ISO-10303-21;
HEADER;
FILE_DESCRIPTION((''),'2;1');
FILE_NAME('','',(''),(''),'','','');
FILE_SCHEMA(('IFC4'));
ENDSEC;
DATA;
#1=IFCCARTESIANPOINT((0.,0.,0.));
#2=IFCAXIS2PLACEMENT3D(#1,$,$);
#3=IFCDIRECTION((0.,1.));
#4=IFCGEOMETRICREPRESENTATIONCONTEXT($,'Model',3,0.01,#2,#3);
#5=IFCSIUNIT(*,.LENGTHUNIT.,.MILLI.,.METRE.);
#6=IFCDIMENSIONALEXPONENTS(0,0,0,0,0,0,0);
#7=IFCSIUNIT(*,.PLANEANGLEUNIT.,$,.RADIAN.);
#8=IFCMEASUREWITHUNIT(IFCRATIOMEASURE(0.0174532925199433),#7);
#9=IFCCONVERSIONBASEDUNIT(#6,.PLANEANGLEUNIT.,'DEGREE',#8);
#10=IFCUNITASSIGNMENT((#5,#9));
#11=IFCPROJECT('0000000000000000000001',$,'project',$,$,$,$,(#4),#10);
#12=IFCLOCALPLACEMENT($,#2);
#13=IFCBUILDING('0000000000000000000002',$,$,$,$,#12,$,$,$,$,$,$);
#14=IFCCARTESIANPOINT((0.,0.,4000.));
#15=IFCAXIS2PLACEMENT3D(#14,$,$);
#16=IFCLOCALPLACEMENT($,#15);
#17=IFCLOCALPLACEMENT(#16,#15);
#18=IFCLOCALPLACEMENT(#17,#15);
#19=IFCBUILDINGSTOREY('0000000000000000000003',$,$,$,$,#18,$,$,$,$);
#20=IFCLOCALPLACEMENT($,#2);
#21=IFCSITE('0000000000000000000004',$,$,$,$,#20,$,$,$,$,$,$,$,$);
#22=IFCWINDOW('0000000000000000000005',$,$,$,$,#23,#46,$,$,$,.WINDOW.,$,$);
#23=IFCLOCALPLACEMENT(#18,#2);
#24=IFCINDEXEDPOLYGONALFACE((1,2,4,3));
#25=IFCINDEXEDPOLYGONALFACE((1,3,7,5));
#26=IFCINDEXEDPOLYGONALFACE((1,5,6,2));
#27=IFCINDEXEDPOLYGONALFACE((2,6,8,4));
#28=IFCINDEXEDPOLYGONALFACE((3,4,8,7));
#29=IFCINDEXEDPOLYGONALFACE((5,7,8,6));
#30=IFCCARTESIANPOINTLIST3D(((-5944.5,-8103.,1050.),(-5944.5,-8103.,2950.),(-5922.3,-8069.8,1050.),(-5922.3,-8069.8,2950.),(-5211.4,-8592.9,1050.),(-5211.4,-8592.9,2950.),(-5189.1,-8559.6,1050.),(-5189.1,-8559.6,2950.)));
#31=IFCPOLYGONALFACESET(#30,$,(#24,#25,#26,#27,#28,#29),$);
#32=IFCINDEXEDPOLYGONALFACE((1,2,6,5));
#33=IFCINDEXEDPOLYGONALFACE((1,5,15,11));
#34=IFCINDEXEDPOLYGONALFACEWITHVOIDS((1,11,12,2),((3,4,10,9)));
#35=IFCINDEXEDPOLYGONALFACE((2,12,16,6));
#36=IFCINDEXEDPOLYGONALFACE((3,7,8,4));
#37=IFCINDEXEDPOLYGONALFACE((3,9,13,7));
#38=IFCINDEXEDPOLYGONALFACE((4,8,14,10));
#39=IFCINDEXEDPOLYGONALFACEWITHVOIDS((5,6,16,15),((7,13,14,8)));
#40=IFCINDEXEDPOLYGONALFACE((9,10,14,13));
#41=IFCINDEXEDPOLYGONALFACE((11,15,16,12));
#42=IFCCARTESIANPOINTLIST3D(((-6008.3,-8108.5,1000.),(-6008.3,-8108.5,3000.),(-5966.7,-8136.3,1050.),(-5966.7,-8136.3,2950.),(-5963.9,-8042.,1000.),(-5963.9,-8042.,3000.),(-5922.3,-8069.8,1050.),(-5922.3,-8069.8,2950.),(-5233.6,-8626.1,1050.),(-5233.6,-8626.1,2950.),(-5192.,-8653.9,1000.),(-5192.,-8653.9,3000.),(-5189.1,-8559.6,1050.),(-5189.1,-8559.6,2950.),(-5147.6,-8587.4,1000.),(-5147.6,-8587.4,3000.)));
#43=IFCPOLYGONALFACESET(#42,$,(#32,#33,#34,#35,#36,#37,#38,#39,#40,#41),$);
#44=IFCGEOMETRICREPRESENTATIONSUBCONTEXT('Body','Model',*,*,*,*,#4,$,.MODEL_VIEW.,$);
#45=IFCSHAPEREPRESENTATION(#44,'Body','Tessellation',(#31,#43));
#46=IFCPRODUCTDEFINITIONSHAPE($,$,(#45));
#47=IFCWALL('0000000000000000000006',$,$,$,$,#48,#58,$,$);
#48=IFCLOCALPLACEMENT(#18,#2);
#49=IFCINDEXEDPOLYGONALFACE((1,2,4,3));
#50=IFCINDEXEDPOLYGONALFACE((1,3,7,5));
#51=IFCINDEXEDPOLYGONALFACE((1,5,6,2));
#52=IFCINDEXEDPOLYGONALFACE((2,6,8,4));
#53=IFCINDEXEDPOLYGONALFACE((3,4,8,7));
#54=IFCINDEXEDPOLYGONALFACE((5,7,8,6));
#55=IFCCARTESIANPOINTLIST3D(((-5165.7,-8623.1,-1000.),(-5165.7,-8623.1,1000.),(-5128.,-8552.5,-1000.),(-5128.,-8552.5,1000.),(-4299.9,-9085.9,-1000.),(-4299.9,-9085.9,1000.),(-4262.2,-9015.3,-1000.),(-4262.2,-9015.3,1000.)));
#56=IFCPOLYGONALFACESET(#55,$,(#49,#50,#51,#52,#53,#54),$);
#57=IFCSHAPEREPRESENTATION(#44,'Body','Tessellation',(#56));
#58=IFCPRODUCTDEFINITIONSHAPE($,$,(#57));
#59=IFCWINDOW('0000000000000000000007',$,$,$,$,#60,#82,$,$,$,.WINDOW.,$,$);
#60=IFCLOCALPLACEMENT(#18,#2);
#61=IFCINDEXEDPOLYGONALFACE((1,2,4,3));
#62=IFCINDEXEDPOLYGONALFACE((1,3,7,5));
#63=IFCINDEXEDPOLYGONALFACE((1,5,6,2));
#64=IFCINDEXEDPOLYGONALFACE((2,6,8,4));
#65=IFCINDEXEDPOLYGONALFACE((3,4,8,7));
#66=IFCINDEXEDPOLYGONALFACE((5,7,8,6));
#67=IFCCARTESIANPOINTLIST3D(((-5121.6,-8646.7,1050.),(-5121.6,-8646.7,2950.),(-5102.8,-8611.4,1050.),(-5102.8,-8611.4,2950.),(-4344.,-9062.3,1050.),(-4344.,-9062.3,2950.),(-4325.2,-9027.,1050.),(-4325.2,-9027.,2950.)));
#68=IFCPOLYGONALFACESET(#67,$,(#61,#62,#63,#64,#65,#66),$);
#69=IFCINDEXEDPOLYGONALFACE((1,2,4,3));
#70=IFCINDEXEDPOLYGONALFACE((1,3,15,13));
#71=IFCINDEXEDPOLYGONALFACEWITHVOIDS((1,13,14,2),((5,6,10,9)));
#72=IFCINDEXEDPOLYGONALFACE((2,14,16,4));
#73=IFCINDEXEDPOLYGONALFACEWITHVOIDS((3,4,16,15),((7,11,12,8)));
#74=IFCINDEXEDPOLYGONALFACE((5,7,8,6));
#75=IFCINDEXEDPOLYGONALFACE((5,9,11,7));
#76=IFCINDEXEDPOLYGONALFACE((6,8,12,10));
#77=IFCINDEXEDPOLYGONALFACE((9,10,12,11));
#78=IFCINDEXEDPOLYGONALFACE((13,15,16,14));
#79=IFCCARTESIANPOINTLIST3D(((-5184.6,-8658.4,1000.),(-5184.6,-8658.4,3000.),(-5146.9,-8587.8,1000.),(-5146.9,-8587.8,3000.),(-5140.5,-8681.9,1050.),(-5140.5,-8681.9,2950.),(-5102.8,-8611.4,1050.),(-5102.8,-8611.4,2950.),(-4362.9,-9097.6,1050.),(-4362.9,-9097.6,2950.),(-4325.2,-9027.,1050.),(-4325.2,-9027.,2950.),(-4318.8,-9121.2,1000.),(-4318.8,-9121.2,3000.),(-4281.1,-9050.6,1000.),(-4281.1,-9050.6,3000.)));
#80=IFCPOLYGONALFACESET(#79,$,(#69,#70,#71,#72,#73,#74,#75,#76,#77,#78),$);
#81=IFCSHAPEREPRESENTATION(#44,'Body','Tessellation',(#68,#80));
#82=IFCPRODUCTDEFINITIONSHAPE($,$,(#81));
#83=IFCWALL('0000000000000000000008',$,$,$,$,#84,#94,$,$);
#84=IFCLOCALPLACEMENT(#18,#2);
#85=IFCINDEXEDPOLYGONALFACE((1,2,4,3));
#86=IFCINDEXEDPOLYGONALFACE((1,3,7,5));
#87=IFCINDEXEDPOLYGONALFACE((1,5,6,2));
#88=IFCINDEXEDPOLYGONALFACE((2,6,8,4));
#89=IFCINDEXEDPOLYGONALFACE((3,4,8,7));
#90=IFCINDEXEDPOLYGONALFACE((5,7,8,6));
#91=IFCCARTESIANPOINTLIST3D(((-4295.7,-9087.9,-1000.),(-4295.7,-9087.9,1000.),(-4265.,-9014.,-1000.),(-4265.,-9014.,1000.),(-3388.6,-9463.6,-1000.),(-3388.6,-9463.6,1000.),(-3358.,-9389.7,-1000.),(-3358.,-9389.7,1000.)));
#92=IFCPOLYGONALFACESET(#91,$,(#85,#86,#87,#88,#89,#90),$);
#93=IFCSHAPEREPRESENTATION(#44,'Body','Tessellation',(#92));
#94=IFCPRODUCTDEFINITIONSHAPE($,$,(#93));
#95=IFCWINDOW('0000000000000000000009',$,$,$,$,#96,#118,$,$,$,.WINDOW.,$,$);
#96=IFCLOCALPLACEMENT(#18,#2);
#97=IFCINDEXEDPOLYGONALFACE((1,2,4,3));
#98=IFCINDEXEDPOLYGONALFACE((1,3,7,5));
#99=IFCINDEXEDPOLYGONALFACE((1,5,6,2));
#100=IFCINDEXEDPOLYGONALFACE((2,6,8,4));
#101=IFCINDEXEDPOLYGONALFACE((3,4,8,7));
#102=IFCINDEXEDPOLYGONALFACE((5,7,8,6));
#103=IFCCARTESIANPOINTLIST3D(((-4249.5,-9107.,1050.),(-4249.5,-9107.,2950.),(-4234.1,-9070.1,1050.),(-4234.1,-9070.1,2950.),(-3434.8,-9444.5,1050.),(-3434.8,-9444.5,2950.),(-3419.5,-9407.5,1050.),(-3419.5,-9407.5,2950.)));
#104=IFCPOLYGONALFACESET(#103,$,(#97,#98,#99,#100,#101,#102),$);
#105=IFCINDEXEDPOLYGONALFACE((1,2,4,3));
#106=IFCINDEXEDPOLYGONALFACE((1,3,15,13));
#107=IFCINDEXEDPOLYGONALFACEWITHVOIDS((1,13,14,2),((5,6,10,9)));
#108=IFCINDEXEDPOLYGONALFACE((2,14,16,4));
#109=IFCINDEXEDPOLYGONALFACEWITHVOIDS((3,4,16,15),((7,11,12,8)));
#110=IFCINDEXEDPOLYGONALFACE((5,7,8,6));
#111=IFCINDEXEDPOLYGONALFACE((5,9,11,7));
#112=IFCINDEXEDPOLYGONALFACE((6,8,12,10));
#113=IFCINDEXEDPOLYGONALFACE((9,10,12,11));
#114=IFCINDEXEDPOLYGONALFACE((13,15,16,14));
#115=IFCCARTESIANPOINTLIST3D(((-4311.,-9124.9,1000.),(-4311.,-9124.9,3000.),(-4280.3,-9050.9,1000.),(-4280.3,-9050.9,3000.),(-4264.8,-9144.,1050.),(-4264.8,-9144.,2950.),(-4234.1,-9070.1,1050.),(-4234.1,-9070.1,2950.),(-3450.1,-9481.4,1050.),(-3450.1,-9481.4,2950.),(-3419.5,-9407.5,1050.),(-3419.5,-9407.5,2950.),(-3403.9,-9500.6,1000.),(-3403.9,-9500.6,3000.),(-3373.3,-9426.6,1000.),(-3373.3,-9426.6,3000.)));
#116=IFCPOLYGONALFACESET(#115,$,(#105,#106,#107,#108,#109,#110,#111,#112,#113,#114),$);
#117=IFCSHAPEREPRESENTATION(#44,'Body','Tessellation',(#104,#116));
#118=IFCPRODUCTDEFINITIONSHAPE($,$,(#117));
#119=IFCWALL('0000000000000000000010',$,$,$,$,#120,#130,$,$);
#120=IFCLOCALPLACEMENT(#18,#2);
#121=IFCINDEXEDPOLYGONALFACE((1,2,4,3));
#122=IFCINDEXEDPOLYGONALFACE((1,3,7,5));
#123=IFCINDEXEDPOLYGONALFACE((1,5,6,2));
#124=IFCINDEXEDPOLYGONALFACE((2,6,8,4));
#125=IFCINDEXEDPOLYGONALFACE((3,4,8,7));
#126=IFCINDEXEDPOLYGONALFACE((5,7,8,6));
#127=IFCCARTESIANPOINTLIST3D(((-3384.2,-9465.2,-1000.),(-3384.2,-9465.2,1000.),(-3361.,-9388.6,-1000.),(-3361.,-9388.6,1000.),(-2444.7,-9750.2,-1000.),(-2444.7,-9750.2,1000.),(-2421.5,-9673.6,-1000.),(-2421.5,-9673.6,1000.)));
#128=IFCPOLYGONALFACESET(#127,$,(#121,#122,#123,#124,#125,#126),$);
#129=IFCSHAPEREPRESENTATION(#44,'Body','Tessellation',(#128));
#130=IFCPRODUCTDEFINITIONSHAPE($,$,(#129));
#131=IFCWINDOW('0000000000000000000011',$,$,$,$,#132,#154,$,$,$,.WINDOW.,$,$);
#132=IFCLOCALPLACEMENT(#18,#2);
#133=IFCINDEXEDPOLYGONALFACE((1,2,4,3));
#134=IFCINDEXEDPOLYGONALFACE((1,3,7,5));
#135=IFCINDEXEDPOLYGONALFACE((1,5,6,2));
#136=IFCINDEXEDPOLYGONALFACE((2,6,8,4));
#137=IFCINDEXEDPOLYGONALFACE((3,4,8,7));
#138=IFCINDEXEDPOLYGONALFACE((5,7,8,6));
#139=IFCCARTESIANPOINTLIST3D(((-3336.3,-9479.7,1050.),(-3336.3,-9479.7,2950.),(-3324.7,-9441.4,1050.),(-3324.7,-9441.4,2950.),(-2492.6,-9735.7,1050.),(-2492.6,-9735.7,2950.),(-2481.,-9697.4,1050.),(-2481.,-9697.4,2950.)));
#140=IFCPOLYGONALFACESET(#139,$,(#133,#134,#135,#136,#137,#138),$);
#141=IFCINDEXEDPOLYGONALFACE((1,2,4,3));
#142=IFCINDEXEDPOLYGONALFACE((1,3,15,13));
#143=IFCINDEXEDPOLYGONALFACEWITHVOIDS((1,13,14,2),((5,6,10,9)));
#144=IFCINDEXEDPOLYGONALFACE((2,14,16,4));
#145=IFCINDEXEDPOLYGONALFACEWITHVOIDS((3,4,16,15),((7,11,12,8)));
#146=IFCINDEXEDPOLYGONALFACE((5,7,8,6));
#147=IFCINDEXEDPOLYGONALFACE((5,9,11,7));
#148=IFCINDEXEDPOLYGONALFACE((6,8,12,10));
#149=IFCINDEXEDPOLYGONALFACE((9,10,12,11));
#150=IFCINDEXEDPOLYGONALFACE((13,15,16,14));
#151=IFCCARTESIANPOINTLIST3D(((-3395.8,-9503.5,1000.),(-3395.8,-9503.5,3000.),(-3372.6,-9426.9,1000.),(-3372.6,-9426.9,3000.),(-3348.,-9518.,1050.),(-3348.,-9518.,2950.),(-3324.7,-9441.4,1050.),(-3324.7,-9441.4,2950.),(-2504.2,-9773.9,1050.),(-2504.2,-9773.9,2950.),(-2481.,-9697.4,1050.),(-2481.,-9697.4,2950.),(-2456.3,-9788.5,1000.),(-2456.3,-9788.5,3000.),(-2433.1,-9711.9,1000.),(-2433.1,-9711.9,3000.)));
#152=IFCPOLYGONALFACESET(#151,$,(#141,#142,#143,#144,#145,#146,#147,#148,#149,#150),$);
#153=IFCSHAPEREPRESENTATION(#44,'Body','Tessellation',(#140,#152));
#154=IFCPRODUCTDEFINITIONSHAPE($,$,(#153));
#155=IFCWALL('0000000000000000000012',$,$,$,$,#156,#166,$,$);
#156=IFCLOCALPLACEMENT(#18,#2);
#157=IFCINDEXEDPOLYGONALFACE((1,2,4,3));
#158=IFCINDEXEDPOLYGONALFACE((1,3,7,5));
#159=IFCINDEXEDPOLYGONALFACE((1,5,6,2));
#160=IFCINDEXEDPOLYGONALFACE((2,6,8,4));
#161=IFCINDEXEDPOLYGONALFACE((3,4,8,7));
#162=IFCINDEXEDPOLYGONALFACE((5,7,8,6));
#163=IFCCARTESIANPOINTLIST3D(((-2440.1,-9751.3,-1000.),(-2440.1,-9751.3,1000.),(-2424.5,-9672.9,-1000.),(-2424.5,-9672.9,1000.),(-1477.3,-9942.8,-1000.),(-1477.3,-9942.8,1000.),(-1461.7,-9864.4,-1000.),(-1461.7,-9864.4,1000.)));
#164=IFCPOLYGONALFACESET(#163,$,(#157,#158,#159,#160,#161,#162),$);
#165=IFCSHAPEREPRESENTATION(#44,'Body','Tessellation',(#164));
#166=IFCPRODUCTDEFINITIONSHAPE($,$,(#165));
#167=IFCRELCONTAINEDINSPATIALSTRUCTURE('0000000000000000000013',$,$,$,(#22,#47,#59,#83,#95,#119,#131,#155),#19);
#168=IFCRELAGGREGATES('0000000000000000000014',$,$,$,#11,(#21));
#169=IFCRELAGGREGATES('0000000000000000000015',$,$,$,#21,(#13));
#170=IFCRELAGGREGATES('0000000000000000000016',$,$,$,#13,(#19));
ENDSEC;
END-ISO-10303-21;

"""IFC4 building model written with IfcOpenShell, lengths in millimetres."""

from ifc_helpers import new_model, entity, si_unit, converted_unit, direction, frame, origin, origin_2d, place, context, subcontext, project, spatial, rectangle, extrude, element, save


model = new_model("IFC4")

# Units and contexts
model_context = context("Model", 3, precision=0.01, world=origin(), true_north=direction((0.0, 1.0)))
body_context = subcontext(model_context, "Body", "Model", "MODEL_VIEW")
ifc_project = project(units=[si_unit("LENGTHUNIT", "METRE", prefix="MILLI"), converted_unit("PLANEANGLEUNIT", "DEGREE", entity("IfcRatioMeasure", 0.0174532925199433), si_unit("PLANEANGLEUNIT", "RADIAN"), dimensions=[0, 0, 0, 0, 0, 0, 0])], contexts=[model_context])

# Site, building, storey
site_placement = place(None, origin())
site = spatial("IfcSite", under=ifc_project, at=site_placement)
building_placement = place(None, origin())
building = spatial("IfcBuilding", under=site, at=building_placement)
placement_1 = place(None, frame((0.0, 0.0, 4000.0)))
placement_2 = place(placement_1, frame((0.0, 0.0, 4000.0)))
storey_placement = place(placement_2, frame((0.0, 0.0, 4000.0)))
storey = spatial("IfcBuildingStorey", under=building, at=storey_placement)

# Shared definitions
cartesian_point_1 = entity("IfcCartesianPoint", [-440.9, -950.0])
shared_polyline = entity("IfcPolyline", [cartesian_point_1, entity("IfcCartesianPoint", [-440.9, 950.0]), entity("IfcCartesianPoint", [-440.9, 950.0]), entity("IfcCartesianPoint", [440.9, 950.0]), entity("IfcCartesianPoint", [440.9, 950.0]), entity("IfcCartesianPoint", [440.9, -950.0]), entity("IfcCartesianPoint", [440.9, -950.0]), entity("IfcCartesianPoint", [-440.9, -950.0]), cartesian_point_1])

# Window
window_1_placement = place(storey_placement, frame((-5555.7, -8314.7, 2000.0), z_axis=(0.0, 0.0, 1.0), x_axis=(8314.694856, -5555.704226, 0.0)))
cartesian_point_2 = entity("IfcCartesianPoint", [-490.9, -1000.0])
element("IfcWindow", 1, at=window_1_placement, inside=storey, PredefinedType="WINDOW", context=body_context, shape_type="SweptSolid", body=[
    entity("IfcExtrudedAreaSolid", entity("IfcArbitraryClosedProfileDef", "AREA", None, shared_polyline), entity("IfcAxis2Placement3D", entity("IfcCartesianPoint", [0.0, 0.0, 0.0]), entity("IfcDirection", [0.0, -1.0, 0.0]), entity("IfcDirection", [1.0, 0.0, 0.0])), entity("IfcDirection", [0.0, 0.0, 1.0]), 40.0),
    entity("IfcExtrudedAreaSolid", entity("IfcArbitraryProfileDefWithVoids", "AREA", None, entity("IfcPolyline", [cartesian_point_2, entity("IfcCartesianPoint", [-490.9, 1000.0]), entity("IfcCartesianPoint", [-490.9, 1000.0]), entity("IfcCartesianPoint", [490.9, 1000.0]), entity("IfcCartesianPoint", [490.9, 1000.0]), entity("IfcCartesianPoint", [490.9, -1000.0]), entity("IfcCartesianPoint", [490.9, -1000.0]), entity("IfcCartesianPoint", [-490.9, -1000.0]), cartesian_point_2]), [shared_polyline]), entity("IfcAxis2Placement3D", entity("IfcCartesianPoint", [0.0, 0.0, 0.0]), entity("IfcDirection", [0.0, -1.0, 0.0]), entity("IfcDirection", [1.0, 0.0, 0.0])), entity("IfcDirection", [0.0, 0.0, 1.0]), 80.0),
])

# Wall
wall_1_placement = place(storey_placement, frame((-4714.0, -8819.2, -1000.0), z_axis=(0.0, 0.0, 1.0), x_axis=(8819.212881, -4713.966924, 0.0)))
element("IfcWall", 2, at=wall_1_placement, inside=storey, context=body_context, shape_type="SweptSolid", body=[
    extrude(rectangle(XDim=981.7, YDim=80.0, at=origin_2d()), origin(), (0.0, 0.0, 1.0), 2000.0),
])

# Window
window_2_placement = place(storey_placement, frame((-4714.0, -8819.2, 2000.0), z_axis=(0.0, 0.0, 1.0), x_axis=(8819.212881, -4713.966924, 0.0)))
cartesian_point_3 = entity("IfcCartesianPoint", [-490.9, -1000.0])
element("IfcWindow", 3, at=window_2_placement, inside=storey, PredefinedType="WINDOW", context=body_context, shape_type="SweptSolid", body=[
    entity("IfcExtrudedAreaSolid", entity("IfcArbitraryClosedProfileDef", "AREA", None, shared_polyline), entity("IfcAxis2Placement3D", entity("IfcCartesianPoint", [0.0, 0.0, 0.0]), entity("IfcDirection", [0.0, -1.0, 0.0]), entity("IfcDirection", [1.0, 0.0, 0.0])), entity("IfcDirection", [0.0, 0.0, 1.0]), 40.0),
    entity("IfcExtrudedAreaSolid", entity("IfcArbitraryProfileDefWithVoids", "AREA", None, entity("IfcPolyline", [cartesian_point_3, entity("IfcCartesianPoint", [-490.9, 1000.0]), entity("IfcCartesianPoint", [-490.9, 1000.0]), entity("IfcCartesianPoint", [490.9, 1000.0]), entity("IfcCartesianPoint", [490.9, 1000.0]), entity("IfcCartesianPoint", [490.9, -1000.0]), entity("IfcCartesianPoint", [490.9, -1000.0]), entity("IfcCartesianPoint", [-490.9, -1000.0]), cartesian_point_3]), [shared_polyline]), entity("IfcAxis2Placement3D", entity("IfcCartesianPoint", [0.0, 0.0, 0.0]), entity("IfcDirection", [0.0, -1.0, 0.0]), entity("IfcDirection", [1.0, 0.0, 0.0])), entity("IfcDirection", [0.0, 0.0, 1.0]), 80.0),
])

# Wall
wall_2_placement = place(storey_placement, frame((-3826.8, -9238.8, -1000.0), z_axis=(0.0, 0.0, 1.0), x_axis=(9238.794759, -3826.835691, 0.0)))
element("IfcWall", 4, at=wall_2_placement, inside=storey, context=body_context, shape_type="SweptSolid", body=[
    extrude(rectangle(XDim=981.7, YDim=80.0, at=origin_2d()), origin(), (0.0, 0.0, 1.0), 2000.0),
])

# Window
window_3_placement = place(storey_placement, frame((-3826.8, -9238.8, 2000.0), z_axis=(0.0, 0.0, 1.0), x_axis=(9238.794759, -3826.835691, 0.0)))
cartesian_point_4 = entity("IfcCartesianPoint", [-490.9, -1000.0])
element("IfcWindow", 5, at=window_3_placement, inside=storey, PredefinedType="WINDOW", context=body_context, shape_type="SweptSolid", body=[
    entity("IfcExtrudedAreaSolid", entity("IfcArbitraryClosedProfileDef", "AREA", None, shared_polyline), entity("IfcAxis2Placement3D", entity("IfcCartesianPoint", [0.0, 0.0, 0.0]), entity("IfcDirection", [0.0, -1.0, 0.0]), entity("IfcDirection", [1.0, 0.0, 0.0])), entity("IfcDirection", [0.0, 0.0, 1.0]), 40.0),
    entity("IfcExtrudedAreaSolid", entity("IfcArbitraryProfileDefWithVoids", "AREA", None, entity("IfcPolyline", [cartesian_point_4, entity("IfcCartesianPoint", [-490.9, 1000.0]), entity("IfcCartesianPoint", [-490.9, 1000.0]), entity("IfcCartesianPoint", [490.9, 1000.0]), entity("IfcCartesianPoint", [490.9, 1000.0]), entity("IfcCartesianPoint", [490.9, -1000.0]), entity("IfcCartesianPoint", [490.9, -1000.0]), entity("IfcCartesianPoint", [-490.9, -1000.0]), cartesian_point_4]), [shared_polyline]), entity("IfcAxis2Placement3D", entity("IfcCartesianPoint", [0.0, 0.0, 0.0]), entity("IfcDirection", [0.0, -1.0, 0.0]), entity("IfcDirection", [1.0, 0.0, 0.0])), entity("IfcDirection", [0.0, 0.0, 1.0]), 80.0),
])

# Wall
wall_3_placement = place(storey_placement, frame((-2902.8, -9569.4, -1000.0), z_axis=(0.0, 0.0, 1.0), x_axis=(9569.403736, -2902.845525, 0.0)))
element("IfcWall", 6, at=wall_3_placement, inside=storey, context=body_context, shape_type="SweptSolid", body=[
    extrude(rectangle(XDim=981.7, YDim=80.0, at=origin_2d()), origin(), (0.0, 0.0, 1.0), 2000.0),
])

# Window
window_4_placement = place(storey_placement, frame((-2902.8, -9569.4, 2000.0), z_axis=(0.0, 0.0, 1.0), x_axis=(9569.403736, -2902.845525, 0.0)))
cartesian_point_5 = entity("IfcCartesianPoint", [-490.9, -1000.0])
element("IfcWindow", 7, at=window_4_placement, inside=storey, PredefinedType="WINDOW", context=body_context, shape_type="SweptSolid", body=[
    entity("IfcExtrudedAreaSolid", entity("IfcArbitraryClosedProfileDef", "AREA", None, shared_polyline), entity("IfcAxis2Placement3D", entity("IfcCartesianPoint", [0.0, 0.0, 0.0]), entity("IfcDirection", [0.0, -1.0, 0.0]), entity("IfcDirection", [1.0, 0.0, 0.0])), entity("IfcDirection", [0.0, 0.0, 1.0]), 40.0),
    entity("IfcExtrudedAreaSolid", entity("IfcArbitraryProfileDefWithVoids", "AREA", None, entity("IfcPolyline", [cartesian_point_5, entity("IfcCartesianPoint", [-490.9, 1000.0]), entity("IfcCartesianPoint", [-490.9, 1000.0]), entity("IfcCartesianPoint", [490.9, 1000.0]), entity("IfcCartesianPoint", [490.9, 1000.0]), entity("IfcCartesianPoint", [490.9, -1000.0]), entity("IfcCartesianPoint", [490.9, -1000.0]), entity("IfcCartesianPoint", [-490.9, -1000.0]), cartesian_point_5]), [shared_polyline]), entity("IfcAxis2Placement3D", entity("IfcCartesianPoint", [0.0, 0.0, 0.0]), entity("IfcDirection", [0.0, -1.0, 0.0]), entity("IfcDirection", [1.0, 0.0, 0.0])), entity("IfcDirection", [0.0, 0.0, 1.0]), 80.0),
])

# Wall
wall_4_placement = place(storey_placement, frame((-1950.9, -9807.9, -1000.0), z_axis=(0.0, 0.0, 1.0), x_axis=(9807.852671, -1950.903888, 0.0)))
element("IfcWall", 8, at=wall_4_placement, inside=storey, context=body_context, shape_type="SweptSolid", body=[
    extrude(rectangle(XDim=981.7, YDim=80.0, at=origin_2d()), origin(), (0.0, 0.0, 1.0), 2000.0),
])

save(model, "model.ifc")
